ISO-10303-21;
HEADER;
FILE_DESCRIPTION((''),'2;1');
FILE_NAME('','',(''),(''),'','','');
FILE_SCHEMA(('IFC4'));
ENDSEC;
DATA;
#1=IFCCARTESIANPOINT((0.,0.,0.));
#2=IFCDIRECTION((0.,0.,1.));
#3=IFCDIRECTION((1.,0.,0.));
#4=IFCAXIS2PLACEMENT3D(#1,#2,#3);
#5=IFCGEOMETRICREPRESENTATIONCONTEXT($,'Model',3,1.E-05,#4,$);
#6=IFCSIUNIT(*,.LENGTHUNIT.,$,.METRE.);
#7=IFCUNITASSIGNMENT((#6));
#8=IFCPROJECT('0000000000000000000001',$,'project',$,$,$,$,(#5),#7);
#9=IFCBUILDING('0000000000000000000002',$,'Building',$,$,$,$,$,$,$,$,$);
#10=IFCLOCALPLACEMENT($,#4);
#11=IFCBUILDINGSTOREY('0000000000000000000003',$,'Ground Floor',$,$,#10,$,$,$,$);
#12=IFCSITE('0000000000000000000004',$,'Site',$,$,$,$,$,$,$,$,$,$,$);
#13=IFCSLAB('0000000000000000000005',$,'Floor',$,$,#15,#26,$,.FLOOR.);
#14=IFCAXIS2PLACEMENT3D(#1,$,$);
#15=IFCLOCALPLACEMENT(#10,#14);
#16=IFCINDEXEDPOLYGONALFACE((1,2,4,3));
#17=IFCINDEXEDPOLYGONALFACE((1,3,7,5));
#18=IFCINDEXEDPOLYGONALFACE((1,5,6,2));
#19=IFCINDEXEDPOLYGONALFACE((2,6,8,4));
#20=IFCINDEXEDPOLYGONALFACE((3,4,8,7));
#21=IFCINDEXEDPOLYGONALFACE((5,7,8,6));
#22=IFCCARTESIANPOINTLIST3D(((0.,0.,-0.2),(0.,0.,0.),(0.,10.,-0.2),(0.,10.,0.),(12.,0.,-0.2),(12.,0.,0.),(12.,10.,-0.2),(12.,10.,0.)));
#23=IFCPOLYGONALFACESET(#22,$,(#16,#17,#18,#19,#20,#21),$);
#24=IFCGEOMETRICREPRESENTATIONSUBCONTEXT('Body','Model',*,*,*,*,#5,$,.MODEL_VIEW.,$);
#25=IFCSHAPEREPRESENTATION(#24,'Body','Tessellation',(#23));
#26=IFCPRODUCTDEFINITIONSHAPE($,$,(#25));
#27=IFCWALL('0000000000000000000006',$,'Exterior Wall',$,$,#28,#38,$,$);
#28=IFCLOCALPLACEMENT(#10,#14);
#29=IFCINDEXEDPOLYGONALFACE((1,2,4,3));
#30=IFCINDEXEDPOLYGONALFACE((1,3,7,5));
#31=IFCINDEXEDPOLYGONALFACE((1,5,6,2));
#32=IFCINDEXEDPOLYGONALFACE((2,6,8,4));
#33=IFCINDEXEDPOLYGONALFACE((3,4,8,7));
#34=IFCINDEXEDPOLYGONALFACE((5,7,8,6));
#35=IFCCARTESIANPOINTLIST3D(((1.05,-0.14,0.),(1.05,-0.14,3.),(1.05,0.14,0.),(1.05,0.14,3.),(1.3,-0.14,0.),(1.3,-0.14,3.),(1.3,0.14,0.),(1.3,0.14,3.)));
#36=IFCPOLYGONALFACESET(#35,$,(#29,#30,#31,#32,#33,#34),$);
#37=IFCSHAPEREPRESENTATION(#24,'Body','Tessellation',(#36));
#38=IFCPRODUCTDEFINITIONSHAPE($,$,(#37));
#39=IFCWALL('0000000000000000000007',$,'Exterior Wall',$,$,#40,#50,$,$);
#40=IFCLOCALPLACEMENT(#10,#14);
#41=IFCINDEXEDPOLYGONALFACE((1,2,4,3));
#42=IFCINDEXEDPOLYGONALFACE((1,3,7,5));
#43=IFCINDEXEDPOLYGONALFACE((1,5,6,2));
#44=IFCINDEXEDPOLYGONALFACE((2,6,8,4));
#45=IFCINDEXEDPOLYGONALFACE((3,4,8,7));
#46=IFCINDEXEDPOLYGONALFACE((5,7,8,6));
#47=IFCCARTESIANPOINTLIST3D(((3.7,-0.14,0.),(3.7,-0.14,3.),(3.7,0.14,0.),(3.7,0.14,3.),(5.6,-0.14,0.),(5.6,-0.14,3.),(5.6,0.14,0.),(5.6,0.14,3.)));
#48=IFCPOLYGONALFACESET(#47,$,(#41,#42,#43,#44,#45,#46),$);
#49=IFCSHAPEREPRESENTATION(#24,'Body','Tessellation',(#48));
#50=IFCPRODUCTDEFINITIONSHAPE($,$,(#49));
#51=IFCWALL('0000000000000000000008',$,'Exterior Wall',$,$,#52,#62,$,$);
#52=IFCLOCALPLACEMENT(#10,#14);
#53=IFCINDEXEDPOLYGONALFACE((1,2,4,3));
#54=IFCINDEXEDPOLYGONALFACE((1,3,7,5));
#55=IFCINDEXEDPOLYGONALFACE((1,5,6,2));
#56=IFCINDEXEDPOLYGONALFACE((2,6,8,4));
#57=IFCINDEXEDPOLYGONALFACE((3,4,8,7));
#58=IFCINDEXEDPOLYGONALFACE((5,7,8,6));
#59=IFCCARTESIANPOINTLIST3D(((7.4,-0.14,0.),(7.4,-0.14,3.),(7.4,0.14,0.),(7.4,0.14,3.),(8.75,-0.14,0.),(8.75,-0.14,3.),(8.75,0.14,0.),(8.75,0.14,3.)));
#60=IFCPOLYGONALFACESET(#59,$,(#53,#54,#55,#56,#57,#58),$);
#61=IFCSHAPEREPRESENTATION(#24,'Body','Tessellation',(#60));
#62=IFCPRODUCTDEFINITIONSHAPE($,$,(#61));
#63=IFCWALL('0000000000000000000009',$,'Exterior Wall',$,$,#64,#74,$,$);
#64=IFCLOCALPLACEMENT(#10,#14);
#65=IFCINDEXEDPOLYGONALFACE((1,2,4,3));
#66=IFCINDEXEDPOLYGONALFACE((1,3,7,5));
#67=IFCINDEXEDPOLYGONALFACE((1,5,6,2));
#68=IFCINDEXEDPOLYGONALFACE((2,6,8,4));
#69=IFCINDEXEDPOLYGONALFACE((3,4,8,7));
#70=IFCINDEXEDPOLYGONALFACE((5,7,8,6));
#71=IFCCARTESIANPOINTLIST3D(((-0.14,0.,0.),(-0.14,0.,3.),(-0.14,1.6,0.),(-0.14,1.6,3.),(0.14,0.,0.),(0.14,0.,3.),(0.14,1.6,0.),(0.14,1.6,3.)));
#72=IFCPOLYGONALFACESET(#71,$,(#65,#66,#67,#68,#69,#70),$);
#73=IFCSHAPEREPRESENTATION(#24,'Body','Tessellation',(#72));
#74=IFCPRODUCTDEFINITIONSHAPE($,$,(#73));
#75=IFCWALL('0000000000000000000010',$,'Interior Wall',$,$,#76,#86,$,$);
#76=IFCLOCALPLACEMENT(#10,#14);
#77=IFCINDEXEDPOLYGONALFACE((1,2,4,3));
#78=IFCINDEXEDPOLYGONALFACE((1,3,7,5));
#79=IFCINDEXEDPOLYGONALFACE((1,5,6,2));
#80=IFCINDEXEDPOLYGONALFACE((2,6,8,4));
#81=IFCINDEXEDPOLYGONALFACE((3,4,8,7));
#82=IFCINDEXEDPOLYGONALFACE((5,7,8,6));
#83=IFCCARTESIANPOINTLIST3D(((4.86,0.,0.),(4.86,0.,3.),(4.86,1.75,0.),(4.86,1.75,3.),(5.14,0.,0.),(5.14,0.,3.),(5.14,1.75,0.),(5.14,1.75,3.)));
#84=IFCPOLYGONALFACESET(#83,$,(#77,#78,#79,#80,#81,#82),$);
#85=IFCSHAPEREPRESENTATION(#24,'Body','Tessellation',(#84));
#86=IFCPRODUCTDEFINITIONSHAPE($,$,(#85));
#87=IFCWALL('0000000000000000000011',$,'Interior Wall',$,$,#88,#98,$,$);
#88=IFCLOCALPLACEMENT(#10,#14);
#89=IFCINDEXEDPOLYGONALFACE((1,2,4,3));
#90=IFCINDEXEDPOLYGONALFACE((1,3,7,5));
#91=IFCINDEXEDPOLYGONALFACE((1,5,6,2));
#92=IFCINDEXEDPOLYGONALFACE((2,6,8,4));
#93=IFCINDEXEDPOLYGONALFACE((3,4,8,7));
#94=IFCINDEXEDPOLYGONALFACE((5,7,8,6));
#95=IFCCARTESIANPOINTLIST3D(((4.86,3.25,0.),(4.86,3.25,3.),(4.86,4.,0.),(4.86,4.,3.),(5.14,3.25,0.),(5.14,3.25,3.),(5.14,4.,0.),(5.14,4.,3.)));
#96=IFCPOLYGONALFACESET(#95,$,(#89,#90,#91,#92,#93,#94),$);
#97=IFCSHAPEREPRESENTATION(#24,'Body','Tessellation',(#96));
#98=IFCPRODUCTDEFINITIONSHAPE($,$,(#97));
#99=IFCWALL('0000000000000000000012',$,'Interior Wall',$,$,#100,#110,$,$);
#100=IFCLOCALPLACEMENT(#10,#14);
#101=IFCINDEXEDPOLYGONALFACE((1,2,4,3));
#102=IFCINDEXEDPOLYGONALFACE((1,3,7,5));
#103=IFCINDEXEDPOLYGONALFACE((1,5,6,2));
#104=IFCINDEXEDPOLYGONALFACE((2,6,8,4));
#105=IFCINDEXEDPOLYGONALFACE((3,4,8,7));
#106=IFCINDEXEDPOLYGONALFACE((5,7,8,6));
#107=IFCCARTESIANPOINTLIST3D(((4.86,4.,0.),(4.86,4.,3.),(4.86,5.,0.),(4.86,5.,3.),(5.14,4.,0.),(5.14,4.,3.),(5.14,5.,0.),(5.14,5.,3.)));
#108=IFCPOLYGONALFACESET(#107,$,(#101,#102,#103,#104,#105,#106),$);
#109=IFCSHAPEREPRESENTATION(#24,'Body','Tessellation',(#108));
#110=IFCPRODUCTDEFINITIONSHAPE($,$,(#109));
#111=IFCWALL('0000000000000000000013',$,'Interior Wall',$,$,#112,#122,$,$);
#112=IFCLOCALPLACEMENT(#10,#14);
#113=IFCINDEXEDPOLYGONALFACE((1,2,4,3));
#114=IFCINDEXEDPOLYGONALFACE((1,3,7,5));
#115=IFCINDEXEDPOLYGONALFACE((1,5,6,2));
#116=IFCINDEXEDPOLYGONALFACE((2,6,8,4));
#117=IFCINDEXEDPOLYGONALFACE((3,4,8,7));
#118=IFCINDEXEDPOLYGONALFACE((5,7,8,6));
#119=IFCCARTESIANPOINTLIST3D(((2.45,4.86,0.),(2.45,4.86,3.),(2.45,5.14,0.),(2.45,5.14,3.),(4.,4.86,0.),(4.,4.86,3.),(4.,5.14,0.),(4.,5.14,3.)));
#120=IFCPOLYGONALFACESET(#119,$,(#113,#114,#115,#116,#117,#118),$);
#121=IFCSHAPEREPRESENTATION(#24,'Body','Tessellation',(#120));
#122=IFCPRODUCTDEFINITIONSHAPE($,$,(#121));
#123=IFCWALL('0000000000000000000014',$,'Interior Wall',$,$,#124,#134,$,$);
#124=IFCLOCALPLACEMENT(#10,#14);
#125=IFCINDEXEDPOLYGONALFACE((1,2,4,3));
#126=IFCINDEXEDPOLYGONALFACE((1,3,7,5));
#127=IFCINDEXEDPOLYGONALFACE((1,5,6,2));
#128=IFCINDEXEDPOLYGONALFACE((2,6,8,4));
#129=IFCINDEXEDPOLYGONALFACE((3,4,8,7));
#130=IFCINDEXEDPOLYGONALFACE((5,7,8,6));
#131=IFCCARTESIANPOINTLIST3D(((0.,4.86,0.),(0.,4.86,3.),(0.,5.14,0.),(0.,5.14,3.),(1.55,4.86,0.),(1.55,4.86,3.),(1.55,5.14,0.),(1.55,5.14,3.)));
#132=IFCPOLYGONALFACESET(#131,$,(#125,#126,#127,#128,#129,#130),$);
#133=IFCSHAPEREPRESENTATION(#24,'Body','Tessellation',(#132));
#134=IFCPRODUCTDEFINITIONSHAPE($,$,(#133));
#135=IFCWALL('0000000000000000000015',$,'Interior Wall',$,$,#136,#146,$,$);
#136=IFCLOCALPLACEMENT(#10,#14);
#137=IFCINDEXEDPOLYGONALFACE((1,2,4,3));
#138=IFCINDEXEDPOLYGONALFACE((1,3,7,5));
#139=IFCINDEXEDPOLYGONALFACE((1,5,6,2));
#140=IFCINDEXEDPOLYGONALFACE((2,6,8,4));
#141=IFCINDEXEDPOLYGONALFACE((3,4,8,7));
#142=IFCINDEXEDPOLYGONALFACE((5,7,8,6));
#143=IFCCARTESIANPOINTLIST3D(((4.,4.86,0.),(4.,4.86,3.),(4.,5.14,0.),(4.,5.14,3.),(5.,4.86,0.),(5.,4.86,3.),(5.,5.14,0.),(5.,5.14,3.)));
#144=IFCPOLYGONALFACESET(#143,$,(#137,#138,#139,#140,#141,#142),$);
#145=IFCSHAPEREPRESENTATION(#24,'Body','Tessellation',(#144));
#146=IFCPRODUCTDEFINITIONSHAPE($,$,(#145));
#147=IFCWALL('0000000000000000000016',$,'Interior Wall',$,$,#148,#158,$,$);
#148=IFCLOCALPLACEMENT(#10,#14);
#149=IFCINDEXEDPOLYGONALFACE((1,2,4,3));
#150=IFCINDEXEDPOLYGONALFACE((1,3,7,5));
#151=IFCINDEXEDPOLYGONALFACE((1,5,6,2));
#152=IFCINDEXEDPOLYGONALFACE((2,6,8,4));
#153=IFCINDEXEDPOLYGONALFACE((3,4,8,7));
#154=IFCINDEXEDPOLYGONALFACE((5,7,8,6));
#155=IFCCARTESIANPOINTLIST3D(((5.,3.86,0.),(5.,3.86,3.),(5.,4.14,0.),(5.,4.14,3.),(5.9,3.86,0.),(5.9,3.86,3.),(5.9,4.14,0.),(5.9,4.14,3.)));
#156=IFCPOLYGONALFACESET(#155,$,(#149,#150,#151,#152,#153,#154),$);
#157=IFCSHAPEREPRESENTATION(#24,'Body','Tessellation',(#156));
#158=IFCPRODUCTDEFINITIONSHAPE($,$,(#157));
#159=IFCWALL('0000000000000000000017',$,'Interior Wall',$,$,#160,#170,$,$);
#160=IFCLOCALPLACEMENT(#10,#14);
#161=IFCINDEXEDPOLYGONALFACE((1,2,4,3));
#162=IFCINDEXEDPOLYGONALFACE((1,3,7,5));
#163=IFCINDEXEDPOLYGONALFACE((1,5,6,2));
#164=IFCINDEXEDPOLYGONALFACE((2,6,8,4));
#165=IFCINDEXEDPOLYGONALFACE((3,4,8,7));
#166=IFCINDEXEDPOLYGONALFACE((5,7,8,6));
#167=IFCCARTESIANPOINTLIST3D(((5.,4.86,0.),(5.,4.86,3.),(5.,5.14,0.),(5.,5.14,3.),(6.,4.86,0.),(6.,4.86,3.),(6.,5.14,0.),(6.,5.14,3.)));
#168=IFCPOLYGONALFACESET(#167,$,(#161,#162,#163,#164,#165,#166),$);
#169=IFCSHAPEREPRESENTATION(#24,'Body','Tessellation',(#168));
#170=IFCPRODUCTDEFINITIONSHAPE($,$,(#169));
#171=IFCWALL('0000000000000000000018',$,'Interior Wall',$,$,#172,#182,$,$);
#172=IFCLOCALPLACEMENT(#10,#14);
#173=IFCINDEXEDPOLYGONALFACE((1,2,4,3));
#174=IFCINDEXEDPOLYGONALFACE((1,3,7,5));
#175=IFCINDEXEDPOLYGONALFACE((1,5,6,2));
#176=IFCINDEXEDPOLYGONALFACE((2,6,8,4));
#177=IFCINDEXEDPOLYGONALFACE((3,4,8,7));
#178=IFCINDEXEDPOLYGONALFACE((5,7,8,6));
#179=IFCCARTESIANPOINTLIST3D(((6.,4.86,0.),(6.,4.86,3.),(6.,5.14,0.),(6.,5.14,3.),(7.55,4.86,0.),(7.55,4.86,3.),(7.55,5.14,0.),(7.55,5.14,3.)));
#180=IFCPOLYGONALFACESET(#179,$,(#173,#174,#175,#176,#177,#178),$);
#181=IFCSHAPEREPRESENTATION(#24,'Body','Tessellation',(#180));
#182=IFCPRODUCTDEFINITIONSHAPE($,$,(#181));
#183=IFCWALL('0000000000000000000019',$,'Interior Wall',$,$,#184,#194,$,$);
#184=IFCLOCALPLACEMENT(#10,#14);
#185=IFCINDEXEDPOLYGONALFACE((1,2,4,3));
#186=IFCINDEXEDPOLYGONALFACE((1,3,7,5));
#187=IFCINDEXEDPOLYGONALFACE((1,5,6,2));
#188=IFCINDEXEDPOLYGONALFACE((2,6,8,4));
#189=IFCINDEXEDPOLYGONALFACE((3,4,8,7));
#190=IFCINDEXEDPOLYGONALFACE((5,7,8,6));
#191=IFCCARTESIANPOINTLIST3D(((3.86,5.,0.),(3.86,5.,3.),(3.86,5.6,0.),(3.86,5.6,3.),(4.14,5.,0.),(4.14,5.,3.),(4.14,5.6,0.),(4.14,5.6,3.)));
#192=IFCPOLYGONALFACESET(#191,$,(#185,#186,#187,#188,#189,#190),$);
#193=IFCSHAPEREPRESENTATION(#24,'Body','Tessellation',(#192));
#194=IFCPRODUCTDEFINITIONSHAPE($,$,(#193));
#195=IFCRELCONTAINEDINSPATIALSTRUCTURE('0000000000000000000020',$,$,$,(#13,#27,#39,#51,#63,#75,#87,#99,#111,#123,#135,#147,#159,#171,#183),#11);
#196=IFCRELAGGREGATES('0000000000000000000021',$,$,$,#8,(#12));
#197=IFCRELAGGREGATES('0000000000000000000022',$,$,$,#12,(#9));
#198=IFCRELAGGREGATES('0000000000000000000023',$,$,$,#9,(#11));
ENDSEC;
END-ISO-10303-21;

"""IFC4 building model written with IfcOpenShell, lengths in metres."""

from ifc_helpers import new_model, si_unit, frame, origin_with_axes, place, context, subcontext, project, spatial, indexed_curve, outline, extrude, element, save


model = new_model("IFC4")

# Units and contexts
model_context = context("Model", 3, precision=1e-05, world=origin_with_axes())
body_context = subcontext(model_context, "Body", "Model", "MODEL_VIEW")
ifc_project = project(units=[si_unit("LENGTHUNIT", "METRE")], contexts=[model_context])

# Site, building, storey
site = spatial("IfcSite", under=ifc_project, Name="Site")
building = spatial("IfcBuilding", under=site, Name="Building")
storey_placement = place(None, origin_with_axes())
storey = spatial("IfcBuildingStorey", under=building, at=storey_placement, Name="Ground Floor")

# Slab
slab_placement = place(storey_placement, frame((0.0, 0.0, -0.2), z_axis=(0.0, 0.0, 1.0), x_axis=(1.0, 0.0, 0.0)))
element("IfcSlab", 1, at=slab_placement, inside=storey, Name="Floor", PredefinedType="FLOOR", context=body_context, shape_type="SweptSolid", body=[
    extrude(outline(indexed_curve([(0.0, 0.0), (12.0, 0.0), (12.0, 10.0), (0.0, 10.0)])), None, (0.0, 0.0, 1.0), 0.2),
])

# Walls
wall_1_placement = place(storey_placement, frame((1.05, 0.0, 0.0), z_axis=(0.0, 0.0, 1.0), x_axis=(1.0, 0.0, 0.0)))
element("IfcWall", 2, at=wall_1_placement, inside=storey, Name="Exterior Wall", context=body_context, shape_type="SweptSolid", body=[
    extrude(outline(indexed_curve([(0.0, 0.0), (0.0, 0.28), (0.25, 0.28), (0.25, 0.0), (0.0, 0.0)], self_intersect=False)), frame((0.0, -0.14, 0.0), z_axis=(0.0, 0.0, 1.0), x_axis=(1.0, 0.0, 0.0)), (0.0, 0.0, 1.0), 3.0),
])
wall_2_placement = place(storey_placement, frame((3.7, 0.0, 0.0), z_axis=(0.0, 0.0, 1.0), x_axis=(1.0, 0.0, 0.0)))
element("IfcWall", 3, at=wall_2_placement, inside=storey, Name="Exterior Wall", context=body_context, shape_type="SweptSolid", body=[
    extrude(outline(indexed_curve([(0.0, 0.0), (0.0, 0.28), (1.9, 0.28), (1.9, 0.0), (0.0, 0.0)], self_intersect=False)), frame((0.0, -0.14, 0.0), z_axis=(0.0, 0.0, 1.0), x_axis=(1.0, 0.0, 0.0)), (0.0, 0.0, 1.0), 3.0),
])
wall_3_placement = place(storey_placement, frame((7.4, 0.0, 0.0), z_axis=(0.0, 0.0, 1.0), x_axis=(1.0, 0.0, 0.0)))
element("IfcWall", 4, at=wall_3_placement, inside=storey, Name="Exterior Wall", context=body_context, shape_type="SweptSolid", body=[
    extrude(outline(indexed_curve([(0.0, 0.0), (0.0, 0.28), (1.35, 0.28), (1.35, 0.0), (0.0, 0.0)], self_intersect=False)), frame((0.0, -0.14, 0.0), z_axis=(0.0, 0.0, 1.0), x_axis=(1.0, 0.0, 0.0)), (0.0, 0.0, 1.0), 3.0),
])
wall_4_placement = place(storey_placement, frame((0.0, 1.6, 0.0), z_axis=(0.0, 0.0, 1.0), x_axis=(0.0, -1.0, 0.0)))
element("IfcWall", 5, at=wall_4_placement, inside=storey, Name="Exterior Wall", context=body_context, shape_type="SweptSolid", body=[
    extrude(outline(indexed_curve([(0.0, 0.0), (0.0, 0.28), (1.6, 0.28), (1.6, 0.0), (0.0, 0.0)], self_intersect=False)), frame((0.0, -0.14, 0.0), z_axis=(0.0, 0.0, 1.0), x_axis=(1.0, 0.0, 0.0)), (0.0, 0.0, 1.0), 3.0),
])
wall_5_placement = place(storey_placement, frame((5.0, 0.0, 0.0), z_axis=(0.0, 0.0, 1.0), x_axis=(0.0, 1.0, 0.0)))
element("IfcWall", 6, at=wall_5_placement, inside=storey, Name="Interior Wall", context=body_context, shape_type="SweptSolid", body=[
    extrude(outline(indexed_curve([(0.0, 0.0), (0.0, 0.28), (1.75, 0.28), (1.75, 0.0), (0.0, 0.0)], self_intersect=False)), frame((0.0, -0.14, 0.0), z_axis=(0.0, 0.0, 1.0), x_axis=(1.0, 0.0, 0.0)), (0.0, 0.0, 1.0), 3.0),
])
wall_6_placement = place(storey_placement, frame((5.0, 3.25, 0.0), z_axis=(0.0, 0.0, 1.0), x_axis=(0.0, 1.0, 0.0)))
element("IfcWall", 7, at=wall_6_placement, inside=storey, Name="Interior Wall", context=body_context, shape_type="SweptSolid", body=[
    extrude(outline(indexed_curve([(0.0, 0.0), (0.0, 0.28), (0.75, 0.28), (0.75, 0.0), (0.0, 0.0)], self_intersect=False)), frame((0.0, -0.14, 0.0), z_axis=(0.0, 0.0, 1.0), x_axis=(1.0, 0.0, 0.0)), (0.0, 0.0, 1.0), 3.0),
])
wall_7_placement = place(storey_placement, frame((5.0, 4.0, 0.0), z_axis=(0.0, 0.0, 1.0), x_axis=(0.0, 1.0, 0.0)))
element("IfcWall", 8, at=wall_7_placement, inside=storey, Name="Interior Wall", context=body_context, shape_type="SweptSolid", body=[
    extrude(outline(indexed_curve([(0.0, 0.0), (0.0, 0.28), (1.0, 0.28), (1.0, 0.0), (0.0, 0.0)], self_intersect=False)), frame((0.0, -0.14, 0.0), z_axis=(0.0, 0.0, 1.0), x_axis=(1.0, 0.0, 0.0)), (0.0, 0.0, 1.0), 3.0),
])
for number, where, z_axis, x_axis, name in (
    (9, (4.0, 5.0, 0.0), (0.0, 0.0, 1.0), (-1.0, 0.0, 0.0), "Interior Wall"),
    (10, (1.55, 5.0, 0.0), (0.0, 0.0, 1.0), (-1.0, 0.0, 0.0), "Interior Wall"),
):
    element("IfcWall", number, at=place(storey_placement, frame(where, z_axis=z_axis, x_axis=x_axis)), inside=storey, Name=name, context=body_context, shape_type="SweptSolid", body=[
        extrude(outline(indexed_curve([(0.0, 0.0), (0.0, 0.28), (1.55, 0.28), (1.55, 0.0), (0.0, 0.0)], self_intersect=False)), frame((0.0, -0.14, 0.0), z_axis=(0.0, 0.0, 1.0), x_axis=(1.0, 0.0, 0.0)), (0.0, 0.0, 1.0), 3.0),
    ])
wall_8_placement = place(storey_placement, frame((5.0, 5.0, 0.0), z_axis=(0.0, 0.0, 1.0), x_axis=(-1.0, 0.0, 0.0)))
element("IfcWall", 11, at=wall_8_placement, inside=storey, Name="Interior Wall", context=body_context, shape_type="SweptSolid", body=[
    extrude(outline(indexed_curve([(0.0, 0.0), (0.0, 0.28), (1.0, 0.28), (1.0, 0.0), (0.0, 0.0)], self_intersect=False)), frame((0.0, -0.14, 0.0), z_axis=(0.0, 0.0, 1.0), x_axis=(1.0, 0.0, 0.0)), (0.0, 0.0, 1.0), 3.0),
])
wall_9_placement = place(storey_placement, frame((5.9, 4.0, 0.0), z_axis=(0.0, 0.0, 1.0), x_axis=(-1.0, 0.0, 0.0)))
element("IfcWall", 12, at=wall_9_placement, inside=storey, Name="Interior Wall", context=body_context, shape_type="SweptSolid", body=[
    extrude(outline(indexed_curve([(0.0, 0.0), (0.0, 0.28), (0.9, 0.28), (0.9, 0.0), (0.0, 0.0)], self_intersect=False)), frame((0.0, -0.14, 0.0), z_axis=(0.0, 0.0, 1.0), x_axis=(1.0, 0.0, 0.0)), (0.0, 0.0, 1.0), 3.0),
])
wall_10_placement = place(storey_placement, frame((6.0, 5.0, 0.0), z_axis=(0.0, 0.0, 1.0), x_axis=(-1.0, 0.0, 0.0)))
element("IfcWall", 13, at=wall_10_placement, inside=storey, Name="Interior Wall", context=body_context, shape_type="SweptSolid", body=[
    extrude(outline(indexed_curve([(0.0, 0.0), (0.0, 0.28), (1.0, 0.28), (1.0, 0.0), (0.0, 0.0)], self_intersect=False)), frame((0.0, -0.14, 0.0), z_axis=(0.0, 0.0, 1.0), x_axis=(1.0, 0.0, 0.0)), (0.0, 0.0, 1.0), 3.0),
])
wall_11_placement = place(storey_placement, frame((7.55, 5.0, 0.0), z_axis=(0.0, 0.0, 1.0), x_axis=(-1.0, 0.0, 0.0)))
element("IfcWall", 14, at=wall_11_placement, inside=storey, Name="Interior Wall", context=body_context, shape_type="SweptSolid", body=[
    extrude(outline(indexed_curve([(0.0, 0.0), (0.0, 0.28), (1.55, 0.28), (1.55, 0.0), (0.0, 0.0)], self_intersect=False)), frame((0.0, -0.14, 0.0), z_axis=(0.0, 0.0, 1.0), x_axis=(1.0, 0.0, 0.0)), (0.0, 0.0, 1.0), 3.0),
])
wall_12_placement = place(storey_placement, frame((4.0, 5.0, 0.0), z_axis=(0.0, 0.0, 1.0), x_axis=(0.0, 1.0, 0.0)))
element("IfcWall", 15, at=wall_12_placement, inside=storey, Name="Interior Wall", context=body_context, shape_type="SweptSolid", body=[
    extrude(outline(indexed_curve([(0.0, 0.0), (0.0, 0.28), (0.6, 0.28), (0.6, 0.0), (0.0, 0.0)], self_intersect=False)), frame((0.0, -0.14, 0.0), z_axis=(0.0, 0.0, 1.0), x_axis=(1.0, 0.0, 0.0)), (0.0, 0.0, 1.0), 3.0),
])

save(model, "model.ifc")
